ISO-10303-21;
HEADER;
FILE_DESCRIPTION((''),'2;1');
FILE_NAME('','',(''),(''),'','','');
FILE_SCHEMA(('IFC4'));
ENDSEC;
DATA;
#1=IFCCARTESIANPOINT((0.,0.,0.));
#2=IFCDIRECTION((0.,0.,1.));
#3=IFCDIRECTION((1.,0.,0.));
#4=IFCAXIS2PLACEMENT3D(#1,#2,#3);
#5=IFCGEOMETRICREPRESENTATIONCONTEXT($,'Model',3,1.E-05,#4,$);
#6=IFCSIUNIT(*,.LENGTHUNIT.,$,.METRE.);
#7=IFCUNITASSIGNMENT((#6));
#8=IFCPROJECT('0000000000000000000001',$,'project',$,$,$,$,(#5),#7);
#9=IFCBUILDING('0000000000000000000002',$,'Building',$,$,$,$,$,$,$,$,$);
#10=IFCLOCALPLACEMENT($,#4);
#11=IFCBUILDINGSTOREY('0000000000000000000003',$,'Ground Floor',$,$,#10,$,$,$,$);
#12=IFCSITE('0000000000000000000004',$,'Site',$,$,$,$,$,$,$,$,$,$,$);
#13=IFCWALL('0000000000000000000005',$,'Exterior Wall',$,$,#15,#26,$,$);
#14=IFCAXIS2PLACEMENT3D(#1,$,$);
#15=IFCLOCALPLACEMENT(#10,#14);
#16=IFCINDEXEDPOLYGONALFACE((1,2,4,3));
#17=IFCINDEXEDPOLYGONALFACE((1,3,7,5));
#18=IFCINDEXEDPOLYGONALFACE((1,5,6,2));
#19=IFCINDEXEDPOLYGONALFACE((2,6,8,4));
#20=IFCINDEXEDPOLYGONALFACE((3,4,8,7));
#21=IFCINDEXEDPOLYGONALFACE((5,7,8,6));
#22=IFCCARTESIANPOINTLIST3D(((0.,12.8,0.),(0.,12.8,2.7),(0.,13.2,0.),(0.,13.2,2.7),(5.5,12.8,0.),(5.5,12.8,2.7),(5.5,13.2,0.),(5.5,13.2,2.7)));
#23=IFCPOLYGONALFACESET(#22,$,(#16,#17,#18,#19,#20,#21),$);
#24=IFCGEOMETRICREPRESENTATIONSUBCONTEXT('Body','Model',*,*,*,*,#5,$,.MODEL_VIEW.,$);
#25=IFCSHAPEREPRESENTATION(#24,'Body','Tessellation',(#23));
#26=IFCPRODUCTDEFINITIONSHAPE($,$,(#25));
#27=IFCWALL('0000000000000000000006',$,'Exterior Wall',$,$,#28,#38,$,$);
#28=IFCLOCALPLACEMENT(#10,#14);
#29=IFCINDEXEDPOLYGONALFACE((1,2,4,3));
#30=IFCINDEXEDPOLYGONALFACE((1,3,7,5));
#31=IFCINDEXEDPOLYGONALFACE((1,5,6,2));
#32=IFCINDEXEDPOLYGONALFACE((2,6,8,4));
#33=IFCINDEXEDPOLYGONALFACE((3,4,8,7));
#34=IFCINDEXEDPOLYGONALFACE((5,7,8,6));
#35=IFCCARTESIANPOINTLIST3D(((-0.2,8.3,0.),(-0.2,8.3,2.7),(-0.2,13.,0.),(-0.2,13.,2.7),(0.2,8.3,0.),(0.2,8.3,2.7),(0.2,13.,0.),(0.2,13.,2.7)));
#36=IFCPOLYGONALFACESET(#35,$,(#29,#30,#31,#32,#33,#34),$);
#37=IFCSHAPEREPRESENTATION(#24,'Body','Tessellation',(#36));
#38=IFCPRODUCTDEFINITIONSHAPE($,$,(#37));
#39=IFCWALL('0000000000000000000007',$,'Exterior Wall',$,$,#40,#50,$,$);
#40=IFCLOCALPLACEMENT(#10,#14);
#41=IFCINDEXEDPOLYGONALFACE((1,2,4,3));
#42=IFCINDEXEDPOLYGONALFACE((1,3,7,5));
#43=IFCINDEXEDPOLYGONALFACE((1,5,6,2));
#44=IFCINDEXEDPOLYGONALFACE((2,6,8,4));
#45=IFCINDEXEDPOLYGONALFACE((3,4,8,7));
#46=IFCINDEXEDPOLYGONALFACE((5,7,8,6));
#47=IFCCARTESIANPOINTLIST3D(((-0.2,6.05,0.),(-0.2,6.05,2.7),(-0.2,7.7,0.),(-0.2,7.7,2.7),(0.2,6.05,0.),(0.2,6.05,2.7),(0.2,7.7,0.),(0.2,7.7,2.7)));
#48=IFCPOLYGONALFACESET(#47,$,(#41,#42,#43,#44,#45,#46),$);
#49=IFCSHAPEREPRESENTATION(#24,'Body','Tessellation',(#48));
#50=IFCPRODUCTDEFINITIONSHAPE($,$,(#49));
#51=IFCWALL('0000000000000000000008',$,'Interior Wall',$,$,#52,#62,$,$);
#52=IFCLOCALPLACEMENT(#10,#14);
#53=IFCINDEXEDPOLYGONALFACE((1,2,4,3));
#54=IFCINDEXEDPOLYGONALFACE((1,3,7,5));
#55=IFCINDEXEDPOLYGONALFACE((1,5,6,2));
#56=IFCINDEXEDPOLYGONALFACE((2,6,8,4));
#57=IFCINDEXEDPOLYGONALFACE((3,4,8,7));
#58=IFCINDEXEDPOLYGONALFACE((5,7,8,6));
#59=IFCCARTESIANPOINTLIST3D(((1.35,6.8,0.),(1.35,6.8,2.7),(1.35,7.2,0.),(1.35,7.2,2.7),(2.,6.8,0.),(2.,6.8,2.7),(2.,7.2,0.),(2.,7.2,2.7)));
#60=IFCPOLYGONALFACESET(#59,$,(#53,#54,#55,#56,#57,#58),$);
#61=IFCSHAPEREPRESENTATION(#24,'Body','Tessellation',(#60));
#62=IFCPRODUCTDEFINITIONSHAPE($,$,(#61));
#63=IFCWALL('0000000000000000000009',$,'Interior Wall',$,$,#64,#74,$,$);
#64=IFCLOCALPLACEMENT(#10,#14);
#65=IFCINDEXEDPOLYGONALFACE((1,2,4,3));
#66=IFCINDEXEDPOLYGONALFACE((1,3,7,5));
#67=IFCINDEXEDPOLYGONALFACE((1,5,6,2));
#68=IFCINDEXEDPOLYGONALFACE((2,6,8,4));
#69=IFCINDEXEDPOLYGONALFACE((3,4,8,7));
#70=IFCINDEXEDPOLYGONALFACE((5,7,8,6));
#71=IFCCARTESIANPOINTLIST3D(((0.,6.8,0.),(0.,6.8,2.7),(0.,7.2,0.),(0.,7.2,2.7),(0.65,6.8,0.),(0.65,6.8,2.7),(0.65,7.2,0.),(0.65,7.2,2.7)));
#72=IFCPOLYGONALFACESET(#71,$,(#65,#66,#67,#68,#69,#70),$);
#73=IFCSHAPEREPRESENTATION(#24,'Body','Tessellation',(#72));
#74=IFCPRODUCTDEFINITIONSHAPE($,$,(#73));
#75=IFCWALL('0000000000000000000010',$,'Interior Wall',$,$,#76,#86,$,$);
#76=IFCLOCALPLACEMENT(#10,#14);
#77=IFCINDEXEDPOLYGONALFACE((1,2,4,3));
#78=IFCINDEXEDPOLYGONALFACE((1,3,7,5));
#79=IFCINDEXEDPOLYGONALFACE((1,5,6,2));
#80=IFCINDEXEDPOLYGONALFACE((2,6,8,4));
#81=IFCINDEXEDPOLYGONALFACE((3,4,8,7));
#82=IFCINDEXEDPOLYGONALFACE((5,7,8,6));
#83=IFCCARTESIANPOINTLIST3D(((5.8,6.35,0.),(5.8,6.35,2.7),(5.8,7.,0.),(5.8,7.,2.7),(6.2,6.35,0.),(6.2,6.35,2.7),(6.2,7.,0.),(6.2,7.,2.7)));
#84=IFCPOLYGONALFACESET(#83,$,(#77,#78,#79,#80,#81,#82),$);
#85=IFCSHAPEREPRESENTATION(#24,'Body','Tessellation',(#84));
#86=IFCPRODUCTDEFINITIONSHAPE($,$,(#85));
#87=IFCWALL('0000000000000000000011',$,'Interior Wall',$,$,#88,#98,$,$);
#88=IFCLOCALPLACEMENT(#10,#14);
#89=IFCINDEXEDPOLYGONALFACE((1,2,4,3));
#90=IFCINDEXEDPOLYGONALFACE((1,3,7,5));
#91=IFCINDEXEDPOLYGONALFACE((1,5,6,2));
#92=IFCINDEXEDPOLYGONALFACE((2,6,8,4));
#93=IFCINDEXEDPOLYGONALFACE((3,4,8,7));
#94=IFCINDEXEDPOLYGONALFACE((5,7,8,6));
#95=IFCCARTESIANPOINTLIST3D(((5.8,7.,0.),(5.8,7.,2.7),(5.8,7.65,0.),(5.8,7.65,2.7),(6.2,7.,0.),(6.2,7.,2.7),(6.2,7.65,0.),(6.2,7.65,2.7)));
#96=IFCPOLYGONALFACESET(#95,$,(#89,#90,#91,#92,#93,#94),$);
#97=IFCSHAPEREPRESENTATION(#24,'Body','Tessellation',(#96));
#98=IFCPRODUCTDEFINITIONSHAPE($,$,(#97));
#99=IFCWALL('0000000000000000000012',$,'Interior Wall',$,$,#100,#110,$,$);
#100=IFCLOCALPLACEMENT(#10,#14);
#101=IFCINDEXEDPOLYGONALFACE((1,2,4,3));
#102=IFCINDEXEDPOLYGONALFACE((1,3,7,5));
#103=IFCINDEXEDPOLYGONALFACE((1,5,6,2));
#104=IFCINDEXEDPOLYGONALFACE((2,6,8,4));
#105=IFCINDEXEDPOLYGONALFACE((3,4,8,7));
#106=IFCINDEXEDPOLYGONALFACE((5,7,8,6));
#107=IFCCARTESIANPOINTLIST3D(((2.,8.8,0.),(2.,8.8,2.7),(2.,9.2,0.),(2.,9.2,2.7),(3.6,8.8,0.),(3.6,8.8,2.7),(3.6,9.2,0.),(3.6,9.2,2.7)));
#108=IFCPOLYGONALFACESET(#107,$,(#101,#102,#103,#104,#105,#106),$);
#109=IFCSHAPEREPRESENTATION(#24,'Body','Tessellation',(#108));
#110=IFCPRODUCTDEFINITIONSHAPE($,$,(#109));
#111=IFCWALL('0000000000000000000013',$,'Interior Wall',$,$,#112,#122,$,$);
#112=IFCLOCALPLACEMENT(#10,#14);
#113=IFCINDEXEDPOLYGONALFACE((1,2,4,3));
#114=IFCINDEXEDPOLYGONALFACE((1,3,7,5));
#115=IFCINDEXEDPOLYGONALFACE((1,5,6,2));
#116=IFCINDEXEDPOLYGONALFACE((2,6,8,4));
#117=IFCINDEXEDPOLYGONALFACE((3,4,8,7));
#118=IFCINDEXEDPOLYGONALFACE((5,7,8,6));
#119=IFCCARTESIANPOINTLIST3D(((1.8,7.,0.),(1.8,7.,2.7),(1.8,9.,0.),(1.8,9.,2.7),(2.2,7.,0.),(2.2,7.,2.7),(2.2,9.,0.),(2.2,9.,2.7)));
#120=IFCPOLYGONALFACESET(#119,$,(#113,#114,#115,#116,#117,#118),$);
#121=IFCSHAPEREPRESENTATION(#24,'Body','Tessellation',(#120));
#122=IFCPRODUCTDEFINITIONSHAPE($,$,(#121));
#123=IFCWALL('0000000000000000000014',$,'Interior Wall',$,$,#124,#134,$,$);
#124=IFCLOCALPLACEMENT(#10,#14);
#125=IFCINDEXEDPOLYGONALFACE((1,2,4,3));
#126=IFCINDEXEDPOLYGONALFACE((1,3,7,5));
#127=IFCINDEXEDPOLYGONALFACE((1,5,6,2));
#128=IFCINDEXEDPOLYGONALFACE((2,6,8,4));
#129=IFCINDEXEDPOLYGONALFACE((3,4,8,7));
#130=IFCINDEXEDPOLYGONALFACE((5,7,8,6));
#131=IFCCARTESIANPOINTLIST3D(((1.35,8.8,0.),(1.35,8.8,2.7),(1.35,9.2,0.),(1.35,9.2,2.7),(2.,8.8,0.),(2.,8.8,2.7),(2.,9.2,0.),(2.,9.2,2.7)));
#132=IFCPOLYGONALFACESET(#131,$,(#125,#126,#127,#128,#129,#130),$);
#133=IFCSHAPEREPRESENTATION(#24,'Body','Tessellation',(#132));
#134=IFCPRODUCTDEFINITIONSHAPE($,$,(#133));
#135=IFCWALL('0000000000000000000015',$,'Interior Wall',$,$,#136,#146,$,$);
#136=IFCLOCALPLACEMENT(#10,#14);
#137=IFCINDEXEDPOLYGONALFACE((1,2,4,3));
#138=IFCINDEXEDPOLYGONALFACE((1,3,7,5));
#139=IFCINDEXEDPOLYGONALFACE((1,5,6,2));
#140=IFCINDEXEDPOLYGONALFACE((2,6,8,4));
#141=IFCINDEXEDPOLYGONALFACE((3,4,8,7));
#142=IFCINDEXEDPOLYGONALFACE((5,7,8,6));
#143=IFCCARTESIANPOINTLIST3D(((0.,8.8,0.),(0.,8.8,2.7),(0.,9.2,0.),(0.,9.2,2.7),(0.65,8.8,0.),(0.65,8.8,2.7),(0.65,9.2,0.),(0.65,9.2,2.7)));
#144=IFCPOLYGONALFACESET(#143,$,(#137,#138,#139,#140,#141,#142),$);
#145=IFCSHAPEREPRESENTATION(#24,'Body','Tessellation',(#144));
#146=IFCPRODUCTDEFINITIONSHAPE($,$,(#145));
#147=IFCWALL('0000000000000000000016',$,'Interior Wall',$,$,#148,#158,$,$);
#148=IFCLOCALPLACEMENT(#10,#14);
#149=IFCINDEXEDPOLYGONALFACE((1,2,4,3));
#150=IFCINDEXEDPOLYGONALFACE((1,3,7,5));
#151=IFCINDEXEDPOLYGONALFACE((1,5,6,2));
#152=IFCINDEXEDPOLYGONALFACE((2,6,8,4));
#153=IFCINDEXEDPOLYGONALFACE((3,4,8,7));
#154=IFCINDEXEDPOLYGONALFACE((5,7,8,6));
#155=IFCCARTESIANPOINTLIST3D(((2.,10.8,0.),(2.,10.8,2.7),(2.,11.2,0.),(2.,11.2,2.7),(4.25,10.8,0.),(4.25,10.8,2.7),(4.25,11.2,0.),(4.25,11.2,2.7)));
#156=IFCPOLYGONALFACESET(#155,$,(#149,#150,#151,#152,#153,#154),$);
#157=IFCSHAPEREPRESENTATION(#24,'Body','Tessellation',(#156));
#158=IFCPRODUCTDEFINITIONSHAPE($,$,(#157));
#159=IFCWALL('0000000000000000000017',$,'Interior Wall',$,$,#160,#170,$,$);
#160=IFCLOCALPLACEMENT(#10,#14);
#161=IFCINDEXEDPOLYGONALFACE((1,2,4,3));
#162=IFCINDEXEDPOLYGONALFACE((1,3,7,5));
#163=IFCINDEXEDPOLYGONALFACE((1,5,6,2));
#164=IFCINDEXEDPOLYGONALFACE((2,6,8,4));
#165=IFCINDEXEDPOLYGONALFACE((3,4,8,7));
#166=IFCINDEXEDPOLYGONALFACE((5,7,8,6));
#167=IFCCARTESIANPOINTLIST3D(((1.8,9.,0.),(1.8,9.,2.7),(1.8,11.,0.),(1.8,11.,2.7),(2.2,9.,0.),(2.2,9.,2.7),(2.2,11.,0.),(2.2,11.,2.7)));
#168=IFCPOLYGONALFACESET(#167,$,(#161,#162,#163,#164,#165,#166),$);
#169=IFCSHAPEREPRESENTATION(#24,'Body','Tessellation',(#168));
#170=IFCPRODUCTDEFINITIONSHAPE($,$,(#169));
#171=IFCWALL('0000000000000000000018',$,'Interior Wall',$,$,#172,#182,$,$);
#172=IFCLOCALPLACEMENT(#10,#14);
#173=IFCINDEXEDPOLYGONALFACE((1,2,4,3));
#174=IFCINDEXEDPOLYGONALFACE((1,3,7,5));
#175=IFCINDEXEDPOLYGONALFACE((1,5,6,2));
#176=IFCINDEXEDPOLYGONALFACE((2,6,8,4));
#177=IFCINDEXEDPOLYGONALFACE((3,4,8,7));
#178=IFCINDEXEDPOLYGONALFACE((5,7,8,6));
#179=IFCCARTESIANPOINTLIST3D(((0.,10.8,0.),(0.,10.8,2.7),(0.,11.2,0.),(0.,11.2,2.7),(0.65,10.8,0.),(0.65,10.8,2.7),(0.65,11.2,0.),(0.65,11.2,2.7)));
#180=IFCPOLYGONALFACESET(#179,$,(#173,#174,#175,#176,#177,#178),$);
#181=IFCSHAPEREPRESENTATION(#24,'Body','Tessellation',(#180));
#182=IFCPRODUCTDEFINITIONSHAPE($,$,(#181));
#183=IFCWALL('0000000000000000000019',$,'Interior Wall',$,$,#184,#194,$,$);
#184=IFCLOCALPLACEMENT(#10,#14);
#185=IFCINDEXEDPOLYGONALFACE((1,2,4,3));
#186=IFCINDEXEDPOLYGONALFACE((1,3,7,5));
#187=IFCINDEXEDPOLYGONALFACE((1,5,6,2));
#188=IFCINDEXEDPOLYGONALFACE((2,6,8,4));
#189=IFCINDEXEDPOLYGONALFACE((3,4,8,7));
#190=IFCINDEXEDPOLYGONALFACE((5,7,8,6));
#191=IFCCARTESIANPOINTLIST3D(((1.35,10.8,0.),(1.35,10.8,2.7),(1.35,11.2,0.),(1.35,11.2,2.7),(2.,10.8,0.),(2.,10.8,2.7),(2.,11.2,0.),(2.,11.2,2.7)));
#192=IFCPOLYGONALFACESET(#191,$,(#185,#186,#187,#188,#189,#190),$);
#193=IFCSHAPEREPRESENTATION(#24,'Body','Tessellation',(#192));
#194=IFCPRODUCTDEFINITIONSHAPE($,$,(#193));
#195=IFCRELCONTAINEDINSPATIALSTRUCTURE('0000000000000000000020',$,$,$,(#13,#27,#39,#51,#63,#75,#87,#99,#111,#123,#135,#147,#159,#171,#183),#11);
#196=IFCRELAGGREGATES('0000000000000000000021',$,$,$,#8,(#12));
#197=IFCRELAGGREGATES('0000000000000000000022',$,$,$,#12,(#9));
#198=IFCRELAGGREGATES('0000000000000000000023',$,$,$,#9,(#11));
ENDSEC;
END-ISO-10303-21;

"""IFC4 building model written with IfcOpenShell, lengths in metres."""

from ifc_helpers import new_model, si_unit, frame, origin_with_axes, place, context, subcontext, project, spatial, indexed_curve, outline, extrude, element, save


model = new_model("IFC4")

# Units and contexts
model_context = context("Model", 3, precision=1e-05, world=origin_with_axes())
body_context = subcontext(model_context, "Body", "Model", "MODEL_VIEW")
ifc_project = project(units=[si_unit("LENGTHUNIT", "METRE")], contexts=[model_context])

# Site, building, storey
site = spatial("IfcSite", under=ifc_project, Name="Site")
building = spatial("IfcBuilding", under=site, Name="Building")
storey_placement = place(None, origin_with_axes())
storey = spatial("IfcBuildingStorey", under=building, at=storey_placement, Name="Ground Floor")

# Walls
wall_1_placement = place(storey_placement, frame((5.5, 13.0, 0.0), z_axis=(0.0, 0.0, 1.0), x_axis=(-1.0, 0.0, 0.0)))
element("IfcWall", 1, at=wall_1_placement, inside=storey, Name="Exterior Wall", context=body_context, shape_type="SweptSolid", body=[
    extrude(outline(indexed_curve([(0.0, 0.0), (0.0, 0.4), (5.5, 0.4), (5.5, 0.0), (0.0, 0.0)], self_intersect=False)), frame((0.0, -0.2, 0.0), z_axis=(0.0, 0.0, 1.0), x_axis=(1.0, 0.0, 0.0)), (0.0, 0.0, 1.0), 2.7),
])
wall_2_placement = place(storey_placement, frame((0.0, 13.0, 0.0), z_axis=(0.0, 0.0, 1.0), x_axis=(0.0, -1.0, 0.0)))
element("IfcWall", 2, at=wall_2_placement, inside=storey, Name="Exterior Wall", context=body_context, shape_type="SweptSolid", body=[
    extrude(outline(indexed_curve([(0.0, 0.0), (0.0, 0.4), (4.7, 0.4), (4.7, 0.0), (0.0, 0.0)], self_intersect=False)), frame((0.0, -0.2, 0.0), z_axis=(0.0, 0.0, 1.0), x_axis=(1.0, 0.0, 0.0)), (0.0, 0.0, 1.0), 2.7),
])
wall_3_placement = place(storey_placement, frame((0.0, 7.7, 0.0), z_axis=(0.0, 0.0, 1.0), x_axis=(0.0, -1.0, 0.0)))
element("IfcWall", 3, at=wall_3_placement, inside=storey, Name="Exterior Wall", context=body_context, shape_type="SweptSolid", body=[
    extrude(outline(indexed_curve([(0.0, 0.0), (0.0, 0.4), (1.65, 0.4), (1.65, 0.0), (0.0, 0.0)], self_intersect=False)), frame((0.0, -0.2, 0.0), z_axis=(0.0, 0.0, 1.0), x_axis=(1.0, 0.0, 0.0)), (0.0, 0.0, 1.0), 2.7),
])
for number, where, z_axis, x_axis, name in (
    (4, (2.0, 7.0, 0.0), (0.0, 0.0, 1.0), (-1.0, 0.0, 0.0), "Interior Wall"),
    (5, (0.65, 7.0, 0.0), (0.0, 0.0, 1.0), (-1.0, 0.0, 0.0), "Interior Wall"),
):
    element("IfcWall", number, at=place(storey_placement, frame(where, z_axis=z_axis, x_axis=x_axis)), inside=storey, Name=name, context=body_context, shape_type="SweptSolid", body=[
        extrude(outline(indexed_curve([(0.0, 0.0), (0.0, 0.4), (0.65, 0.4), (0.65, 0.0), (0.0, 0.0)], self_intersect=False)), frame((0.0, -0.2, 0.0), z_axis=(0.0, 0.0, 1.0), x_axis=(1.0, 0.0, 0.0)), (0.0, 0.0, 1.0), 2.7),
    ])
for number, where, z_axis, x_axis, name in (
    (6, (6.0, 6.35, 0.0), (0.0, 0.0, 1.0), (0.0, 1.0, 0.0), "Interior Wall"),
    (7, (6.0, 7.0, 0.0), (0.0, 0.0, 1.0), (0.0, 1.0, 0.0), "Interior Wall"),
):
    element("IfcWall", number, at=place(storey_placement, frame(where, z_axis=z_axis, x_axis=x_axis)), inside=storey, Name=name, context=body_context, shape_type="SweptSolid", body=[
        extrude(outline(indexed_curve([(0.0, 0.0), (0.0, 0.4), (0.65, 0.4), (0.65, 0.0), (0.0, 0.0)], self_intersect=False)), frame((0.0, -0.2, 0.0), z_axis=(0.0, 0.0, 1.0), x_axis=(1.0, 0.0, 0.0)), (0.0, 0.0, 1.0), 2.7),
    ])
wall_4_placement = place(storey_placement, frame((3.6, 9.0, 0.0), z_axis=(0.0, 0.0, 1.0), x_axis=(-1.0, 0.0, 0.0)))
element("IfcWall", 8, at=wall_4_placement, inside=storey, Name="Interior Wall", context=body_context, shape_type="SweptSolid", body=[
    extrude(outline(indexed_curve([(0.0, 0.0), (0.0, 0.4), (1.6, 0.4), (1.6, 0.0), (0.0, 0.0)], self_intersect=False)), frame((0.0, -0.2, 0.0), z_axis=(0.0, 0.0, 1.0), x_axis=(1.0, 0.0, 0.0)), (0.0, 0.0, 1.0), 2.7),
])
wall_5_placement = place(storey_placement, frame((2.0, 9.0, 0.0), z_axis=(0.0, 0.0, 1.0), x_axis=(0.0, -1.0, 0.0)))
element("IfcWall", 9, at=wall_5_placement, inside=storey, Name="Interior Wall", context=body_context, shape_type="SweptSolid", body=[
    extrude(outline(indexed_curve([(0.0, 0.0), (0.0, 0.4), (2.0, 0.4), (2.0, 0.0), (0.0, 0.0)], self_intersect=False)), frame((0.0, -0.2, 0.0), z_axis=(0.0, 0.0, 1.0), x_axis=(1.0, 0.0, 0.0)), (0.0, 0.0, 1.0), 2.7),
])
for number, where, z_axis, x_axis, name in (
    (10, (2.0, 9.0, 0.0), (0.0, 0.0, 1.0), (-1.0, 0.0, 0.0), "Interior Wall"),
    (11, (0.65, 9.0, 0.0), (0.0, 0.0, 1.0), (-1.0, 0.0, 0.0), "Interior Wall"),
):
    element("IfcWall", number, at=place(storey_placement, frame(where, z_axis=z_axis, x_axis=x_axis)), inside=storey, Name=name, context=body_context, shape_type="SweptSolid", body=[
        extrude(outline(indexed_curve([(0.0, 0.0), (0.0, 0.4), (0.65, 0.4), (0.65, 0.0), (0.0, 0.0)], self_intersect=False)), frame((0.0, -0.2, 0.0), z_axis=(0.0, 0.0, 1.0), x_axis=(1.0, 0.0, 0.0)), (0.0, 0.0, 1.0), 2.7),
    ])
wall_6_placement = place(storey_placement, frame((4.25, 11.0, 0.0), z_axis=(0.0, 0.0, 1.0), x_axis=(-1.0, 0.0, 0.0)))
element("IfcWall", 12, at=wall_6_placement, inside=storey, Name="Interior Wall", context=body_context, shape_type="SweptSolid", body=[
    extrude(outline(indexed_curve([(0.0, 0.0), (0.0, 0.4), (2.25, 0.4), (2.25, 0.0), (0.0, 0.0)], self_intersect=False)), frame((0.0, -0.2, 0.0), z_axis=(0.0, 0.0, 1.0), x_axis=(1.0, 0.0, 0.0)), (0.0, 0.0, 1.0), 2.7),
])
wall_7_placement = place(storey_placement, frame((2.0, 11.0, 0.0), z_axis=(0.0, 0.0, 1.0), x_axis=(0.0, -1.0, 0.0)))
element("IfcWall", 13, at=wall_7_placement, inside=storey, Name="Interior Wall", context=body_context, shape_type="SweptSolid", body=[
    extrude(outline(indexed_curve([(0.0, 0.0), (0.0, 0.4), (2.0, 0.4), (2.0, 0.0), (0.0, 0.0)], self_intersect=False)), frame((0.0, -0.2, 0.0), z_axis=(0.0, 0.0, 1.0), x_axis=(1.0, 0.0, 0.0)), (0.0, 0.0, 1.0), 2.7),
])
wall_8_placement = place(storey_placement, frame((0.0, 11.0, 0.0), z_axis=(0.0, 0.0, 1.0), x_axis=(1.0, 0.0, 0.0)))
element("IfcWall", 14, at=wall_8_placement, inside=storey, Name="Interior Wall", context=body_context, shape_type="SweptSolid", body=[
    extrude(outline(indexed_curve([(0.0, 0.0), (0.0, 0.4), (0.65, 0.4), (0.65, 0.0), (0.0, 0.0)], self_intersect=False)), frame((0.0, -0.2, 0.0), z_axis=(0.0, 0.0, 1.0), x_axis=(1.0, 0.0, 0.0)), (0.0, 0.0, 1.0), 2.7),
])
wall_9_placement = place(storey_placement, frame((1.35, 11.0, 0.0), z_axis=(0.0, 0.0, 1.0), x_axis=(1.0, 0.0, 0.0)))
element("IfcWall", 15, at=wall_9_placement, inside=storey, Name="Interior Wall", context=body_context, shape_type="SweptSolid", body=[
    extrude(outline(indexed_curve([(0.0, 0.0), (0.0, 0.4), (0.65, 0.4), (0.65, 0.0), (0.0, 0.0)], self_intersect=False)), frame((0.0, -0.2, 0.0), z_axis=(0.0, 0.0, 1.0), x_axis=(1.0, 0.0, 0.0)), (0.0, 0.0, 1.0), 2.7),
])

save(model, "model.ifc")
